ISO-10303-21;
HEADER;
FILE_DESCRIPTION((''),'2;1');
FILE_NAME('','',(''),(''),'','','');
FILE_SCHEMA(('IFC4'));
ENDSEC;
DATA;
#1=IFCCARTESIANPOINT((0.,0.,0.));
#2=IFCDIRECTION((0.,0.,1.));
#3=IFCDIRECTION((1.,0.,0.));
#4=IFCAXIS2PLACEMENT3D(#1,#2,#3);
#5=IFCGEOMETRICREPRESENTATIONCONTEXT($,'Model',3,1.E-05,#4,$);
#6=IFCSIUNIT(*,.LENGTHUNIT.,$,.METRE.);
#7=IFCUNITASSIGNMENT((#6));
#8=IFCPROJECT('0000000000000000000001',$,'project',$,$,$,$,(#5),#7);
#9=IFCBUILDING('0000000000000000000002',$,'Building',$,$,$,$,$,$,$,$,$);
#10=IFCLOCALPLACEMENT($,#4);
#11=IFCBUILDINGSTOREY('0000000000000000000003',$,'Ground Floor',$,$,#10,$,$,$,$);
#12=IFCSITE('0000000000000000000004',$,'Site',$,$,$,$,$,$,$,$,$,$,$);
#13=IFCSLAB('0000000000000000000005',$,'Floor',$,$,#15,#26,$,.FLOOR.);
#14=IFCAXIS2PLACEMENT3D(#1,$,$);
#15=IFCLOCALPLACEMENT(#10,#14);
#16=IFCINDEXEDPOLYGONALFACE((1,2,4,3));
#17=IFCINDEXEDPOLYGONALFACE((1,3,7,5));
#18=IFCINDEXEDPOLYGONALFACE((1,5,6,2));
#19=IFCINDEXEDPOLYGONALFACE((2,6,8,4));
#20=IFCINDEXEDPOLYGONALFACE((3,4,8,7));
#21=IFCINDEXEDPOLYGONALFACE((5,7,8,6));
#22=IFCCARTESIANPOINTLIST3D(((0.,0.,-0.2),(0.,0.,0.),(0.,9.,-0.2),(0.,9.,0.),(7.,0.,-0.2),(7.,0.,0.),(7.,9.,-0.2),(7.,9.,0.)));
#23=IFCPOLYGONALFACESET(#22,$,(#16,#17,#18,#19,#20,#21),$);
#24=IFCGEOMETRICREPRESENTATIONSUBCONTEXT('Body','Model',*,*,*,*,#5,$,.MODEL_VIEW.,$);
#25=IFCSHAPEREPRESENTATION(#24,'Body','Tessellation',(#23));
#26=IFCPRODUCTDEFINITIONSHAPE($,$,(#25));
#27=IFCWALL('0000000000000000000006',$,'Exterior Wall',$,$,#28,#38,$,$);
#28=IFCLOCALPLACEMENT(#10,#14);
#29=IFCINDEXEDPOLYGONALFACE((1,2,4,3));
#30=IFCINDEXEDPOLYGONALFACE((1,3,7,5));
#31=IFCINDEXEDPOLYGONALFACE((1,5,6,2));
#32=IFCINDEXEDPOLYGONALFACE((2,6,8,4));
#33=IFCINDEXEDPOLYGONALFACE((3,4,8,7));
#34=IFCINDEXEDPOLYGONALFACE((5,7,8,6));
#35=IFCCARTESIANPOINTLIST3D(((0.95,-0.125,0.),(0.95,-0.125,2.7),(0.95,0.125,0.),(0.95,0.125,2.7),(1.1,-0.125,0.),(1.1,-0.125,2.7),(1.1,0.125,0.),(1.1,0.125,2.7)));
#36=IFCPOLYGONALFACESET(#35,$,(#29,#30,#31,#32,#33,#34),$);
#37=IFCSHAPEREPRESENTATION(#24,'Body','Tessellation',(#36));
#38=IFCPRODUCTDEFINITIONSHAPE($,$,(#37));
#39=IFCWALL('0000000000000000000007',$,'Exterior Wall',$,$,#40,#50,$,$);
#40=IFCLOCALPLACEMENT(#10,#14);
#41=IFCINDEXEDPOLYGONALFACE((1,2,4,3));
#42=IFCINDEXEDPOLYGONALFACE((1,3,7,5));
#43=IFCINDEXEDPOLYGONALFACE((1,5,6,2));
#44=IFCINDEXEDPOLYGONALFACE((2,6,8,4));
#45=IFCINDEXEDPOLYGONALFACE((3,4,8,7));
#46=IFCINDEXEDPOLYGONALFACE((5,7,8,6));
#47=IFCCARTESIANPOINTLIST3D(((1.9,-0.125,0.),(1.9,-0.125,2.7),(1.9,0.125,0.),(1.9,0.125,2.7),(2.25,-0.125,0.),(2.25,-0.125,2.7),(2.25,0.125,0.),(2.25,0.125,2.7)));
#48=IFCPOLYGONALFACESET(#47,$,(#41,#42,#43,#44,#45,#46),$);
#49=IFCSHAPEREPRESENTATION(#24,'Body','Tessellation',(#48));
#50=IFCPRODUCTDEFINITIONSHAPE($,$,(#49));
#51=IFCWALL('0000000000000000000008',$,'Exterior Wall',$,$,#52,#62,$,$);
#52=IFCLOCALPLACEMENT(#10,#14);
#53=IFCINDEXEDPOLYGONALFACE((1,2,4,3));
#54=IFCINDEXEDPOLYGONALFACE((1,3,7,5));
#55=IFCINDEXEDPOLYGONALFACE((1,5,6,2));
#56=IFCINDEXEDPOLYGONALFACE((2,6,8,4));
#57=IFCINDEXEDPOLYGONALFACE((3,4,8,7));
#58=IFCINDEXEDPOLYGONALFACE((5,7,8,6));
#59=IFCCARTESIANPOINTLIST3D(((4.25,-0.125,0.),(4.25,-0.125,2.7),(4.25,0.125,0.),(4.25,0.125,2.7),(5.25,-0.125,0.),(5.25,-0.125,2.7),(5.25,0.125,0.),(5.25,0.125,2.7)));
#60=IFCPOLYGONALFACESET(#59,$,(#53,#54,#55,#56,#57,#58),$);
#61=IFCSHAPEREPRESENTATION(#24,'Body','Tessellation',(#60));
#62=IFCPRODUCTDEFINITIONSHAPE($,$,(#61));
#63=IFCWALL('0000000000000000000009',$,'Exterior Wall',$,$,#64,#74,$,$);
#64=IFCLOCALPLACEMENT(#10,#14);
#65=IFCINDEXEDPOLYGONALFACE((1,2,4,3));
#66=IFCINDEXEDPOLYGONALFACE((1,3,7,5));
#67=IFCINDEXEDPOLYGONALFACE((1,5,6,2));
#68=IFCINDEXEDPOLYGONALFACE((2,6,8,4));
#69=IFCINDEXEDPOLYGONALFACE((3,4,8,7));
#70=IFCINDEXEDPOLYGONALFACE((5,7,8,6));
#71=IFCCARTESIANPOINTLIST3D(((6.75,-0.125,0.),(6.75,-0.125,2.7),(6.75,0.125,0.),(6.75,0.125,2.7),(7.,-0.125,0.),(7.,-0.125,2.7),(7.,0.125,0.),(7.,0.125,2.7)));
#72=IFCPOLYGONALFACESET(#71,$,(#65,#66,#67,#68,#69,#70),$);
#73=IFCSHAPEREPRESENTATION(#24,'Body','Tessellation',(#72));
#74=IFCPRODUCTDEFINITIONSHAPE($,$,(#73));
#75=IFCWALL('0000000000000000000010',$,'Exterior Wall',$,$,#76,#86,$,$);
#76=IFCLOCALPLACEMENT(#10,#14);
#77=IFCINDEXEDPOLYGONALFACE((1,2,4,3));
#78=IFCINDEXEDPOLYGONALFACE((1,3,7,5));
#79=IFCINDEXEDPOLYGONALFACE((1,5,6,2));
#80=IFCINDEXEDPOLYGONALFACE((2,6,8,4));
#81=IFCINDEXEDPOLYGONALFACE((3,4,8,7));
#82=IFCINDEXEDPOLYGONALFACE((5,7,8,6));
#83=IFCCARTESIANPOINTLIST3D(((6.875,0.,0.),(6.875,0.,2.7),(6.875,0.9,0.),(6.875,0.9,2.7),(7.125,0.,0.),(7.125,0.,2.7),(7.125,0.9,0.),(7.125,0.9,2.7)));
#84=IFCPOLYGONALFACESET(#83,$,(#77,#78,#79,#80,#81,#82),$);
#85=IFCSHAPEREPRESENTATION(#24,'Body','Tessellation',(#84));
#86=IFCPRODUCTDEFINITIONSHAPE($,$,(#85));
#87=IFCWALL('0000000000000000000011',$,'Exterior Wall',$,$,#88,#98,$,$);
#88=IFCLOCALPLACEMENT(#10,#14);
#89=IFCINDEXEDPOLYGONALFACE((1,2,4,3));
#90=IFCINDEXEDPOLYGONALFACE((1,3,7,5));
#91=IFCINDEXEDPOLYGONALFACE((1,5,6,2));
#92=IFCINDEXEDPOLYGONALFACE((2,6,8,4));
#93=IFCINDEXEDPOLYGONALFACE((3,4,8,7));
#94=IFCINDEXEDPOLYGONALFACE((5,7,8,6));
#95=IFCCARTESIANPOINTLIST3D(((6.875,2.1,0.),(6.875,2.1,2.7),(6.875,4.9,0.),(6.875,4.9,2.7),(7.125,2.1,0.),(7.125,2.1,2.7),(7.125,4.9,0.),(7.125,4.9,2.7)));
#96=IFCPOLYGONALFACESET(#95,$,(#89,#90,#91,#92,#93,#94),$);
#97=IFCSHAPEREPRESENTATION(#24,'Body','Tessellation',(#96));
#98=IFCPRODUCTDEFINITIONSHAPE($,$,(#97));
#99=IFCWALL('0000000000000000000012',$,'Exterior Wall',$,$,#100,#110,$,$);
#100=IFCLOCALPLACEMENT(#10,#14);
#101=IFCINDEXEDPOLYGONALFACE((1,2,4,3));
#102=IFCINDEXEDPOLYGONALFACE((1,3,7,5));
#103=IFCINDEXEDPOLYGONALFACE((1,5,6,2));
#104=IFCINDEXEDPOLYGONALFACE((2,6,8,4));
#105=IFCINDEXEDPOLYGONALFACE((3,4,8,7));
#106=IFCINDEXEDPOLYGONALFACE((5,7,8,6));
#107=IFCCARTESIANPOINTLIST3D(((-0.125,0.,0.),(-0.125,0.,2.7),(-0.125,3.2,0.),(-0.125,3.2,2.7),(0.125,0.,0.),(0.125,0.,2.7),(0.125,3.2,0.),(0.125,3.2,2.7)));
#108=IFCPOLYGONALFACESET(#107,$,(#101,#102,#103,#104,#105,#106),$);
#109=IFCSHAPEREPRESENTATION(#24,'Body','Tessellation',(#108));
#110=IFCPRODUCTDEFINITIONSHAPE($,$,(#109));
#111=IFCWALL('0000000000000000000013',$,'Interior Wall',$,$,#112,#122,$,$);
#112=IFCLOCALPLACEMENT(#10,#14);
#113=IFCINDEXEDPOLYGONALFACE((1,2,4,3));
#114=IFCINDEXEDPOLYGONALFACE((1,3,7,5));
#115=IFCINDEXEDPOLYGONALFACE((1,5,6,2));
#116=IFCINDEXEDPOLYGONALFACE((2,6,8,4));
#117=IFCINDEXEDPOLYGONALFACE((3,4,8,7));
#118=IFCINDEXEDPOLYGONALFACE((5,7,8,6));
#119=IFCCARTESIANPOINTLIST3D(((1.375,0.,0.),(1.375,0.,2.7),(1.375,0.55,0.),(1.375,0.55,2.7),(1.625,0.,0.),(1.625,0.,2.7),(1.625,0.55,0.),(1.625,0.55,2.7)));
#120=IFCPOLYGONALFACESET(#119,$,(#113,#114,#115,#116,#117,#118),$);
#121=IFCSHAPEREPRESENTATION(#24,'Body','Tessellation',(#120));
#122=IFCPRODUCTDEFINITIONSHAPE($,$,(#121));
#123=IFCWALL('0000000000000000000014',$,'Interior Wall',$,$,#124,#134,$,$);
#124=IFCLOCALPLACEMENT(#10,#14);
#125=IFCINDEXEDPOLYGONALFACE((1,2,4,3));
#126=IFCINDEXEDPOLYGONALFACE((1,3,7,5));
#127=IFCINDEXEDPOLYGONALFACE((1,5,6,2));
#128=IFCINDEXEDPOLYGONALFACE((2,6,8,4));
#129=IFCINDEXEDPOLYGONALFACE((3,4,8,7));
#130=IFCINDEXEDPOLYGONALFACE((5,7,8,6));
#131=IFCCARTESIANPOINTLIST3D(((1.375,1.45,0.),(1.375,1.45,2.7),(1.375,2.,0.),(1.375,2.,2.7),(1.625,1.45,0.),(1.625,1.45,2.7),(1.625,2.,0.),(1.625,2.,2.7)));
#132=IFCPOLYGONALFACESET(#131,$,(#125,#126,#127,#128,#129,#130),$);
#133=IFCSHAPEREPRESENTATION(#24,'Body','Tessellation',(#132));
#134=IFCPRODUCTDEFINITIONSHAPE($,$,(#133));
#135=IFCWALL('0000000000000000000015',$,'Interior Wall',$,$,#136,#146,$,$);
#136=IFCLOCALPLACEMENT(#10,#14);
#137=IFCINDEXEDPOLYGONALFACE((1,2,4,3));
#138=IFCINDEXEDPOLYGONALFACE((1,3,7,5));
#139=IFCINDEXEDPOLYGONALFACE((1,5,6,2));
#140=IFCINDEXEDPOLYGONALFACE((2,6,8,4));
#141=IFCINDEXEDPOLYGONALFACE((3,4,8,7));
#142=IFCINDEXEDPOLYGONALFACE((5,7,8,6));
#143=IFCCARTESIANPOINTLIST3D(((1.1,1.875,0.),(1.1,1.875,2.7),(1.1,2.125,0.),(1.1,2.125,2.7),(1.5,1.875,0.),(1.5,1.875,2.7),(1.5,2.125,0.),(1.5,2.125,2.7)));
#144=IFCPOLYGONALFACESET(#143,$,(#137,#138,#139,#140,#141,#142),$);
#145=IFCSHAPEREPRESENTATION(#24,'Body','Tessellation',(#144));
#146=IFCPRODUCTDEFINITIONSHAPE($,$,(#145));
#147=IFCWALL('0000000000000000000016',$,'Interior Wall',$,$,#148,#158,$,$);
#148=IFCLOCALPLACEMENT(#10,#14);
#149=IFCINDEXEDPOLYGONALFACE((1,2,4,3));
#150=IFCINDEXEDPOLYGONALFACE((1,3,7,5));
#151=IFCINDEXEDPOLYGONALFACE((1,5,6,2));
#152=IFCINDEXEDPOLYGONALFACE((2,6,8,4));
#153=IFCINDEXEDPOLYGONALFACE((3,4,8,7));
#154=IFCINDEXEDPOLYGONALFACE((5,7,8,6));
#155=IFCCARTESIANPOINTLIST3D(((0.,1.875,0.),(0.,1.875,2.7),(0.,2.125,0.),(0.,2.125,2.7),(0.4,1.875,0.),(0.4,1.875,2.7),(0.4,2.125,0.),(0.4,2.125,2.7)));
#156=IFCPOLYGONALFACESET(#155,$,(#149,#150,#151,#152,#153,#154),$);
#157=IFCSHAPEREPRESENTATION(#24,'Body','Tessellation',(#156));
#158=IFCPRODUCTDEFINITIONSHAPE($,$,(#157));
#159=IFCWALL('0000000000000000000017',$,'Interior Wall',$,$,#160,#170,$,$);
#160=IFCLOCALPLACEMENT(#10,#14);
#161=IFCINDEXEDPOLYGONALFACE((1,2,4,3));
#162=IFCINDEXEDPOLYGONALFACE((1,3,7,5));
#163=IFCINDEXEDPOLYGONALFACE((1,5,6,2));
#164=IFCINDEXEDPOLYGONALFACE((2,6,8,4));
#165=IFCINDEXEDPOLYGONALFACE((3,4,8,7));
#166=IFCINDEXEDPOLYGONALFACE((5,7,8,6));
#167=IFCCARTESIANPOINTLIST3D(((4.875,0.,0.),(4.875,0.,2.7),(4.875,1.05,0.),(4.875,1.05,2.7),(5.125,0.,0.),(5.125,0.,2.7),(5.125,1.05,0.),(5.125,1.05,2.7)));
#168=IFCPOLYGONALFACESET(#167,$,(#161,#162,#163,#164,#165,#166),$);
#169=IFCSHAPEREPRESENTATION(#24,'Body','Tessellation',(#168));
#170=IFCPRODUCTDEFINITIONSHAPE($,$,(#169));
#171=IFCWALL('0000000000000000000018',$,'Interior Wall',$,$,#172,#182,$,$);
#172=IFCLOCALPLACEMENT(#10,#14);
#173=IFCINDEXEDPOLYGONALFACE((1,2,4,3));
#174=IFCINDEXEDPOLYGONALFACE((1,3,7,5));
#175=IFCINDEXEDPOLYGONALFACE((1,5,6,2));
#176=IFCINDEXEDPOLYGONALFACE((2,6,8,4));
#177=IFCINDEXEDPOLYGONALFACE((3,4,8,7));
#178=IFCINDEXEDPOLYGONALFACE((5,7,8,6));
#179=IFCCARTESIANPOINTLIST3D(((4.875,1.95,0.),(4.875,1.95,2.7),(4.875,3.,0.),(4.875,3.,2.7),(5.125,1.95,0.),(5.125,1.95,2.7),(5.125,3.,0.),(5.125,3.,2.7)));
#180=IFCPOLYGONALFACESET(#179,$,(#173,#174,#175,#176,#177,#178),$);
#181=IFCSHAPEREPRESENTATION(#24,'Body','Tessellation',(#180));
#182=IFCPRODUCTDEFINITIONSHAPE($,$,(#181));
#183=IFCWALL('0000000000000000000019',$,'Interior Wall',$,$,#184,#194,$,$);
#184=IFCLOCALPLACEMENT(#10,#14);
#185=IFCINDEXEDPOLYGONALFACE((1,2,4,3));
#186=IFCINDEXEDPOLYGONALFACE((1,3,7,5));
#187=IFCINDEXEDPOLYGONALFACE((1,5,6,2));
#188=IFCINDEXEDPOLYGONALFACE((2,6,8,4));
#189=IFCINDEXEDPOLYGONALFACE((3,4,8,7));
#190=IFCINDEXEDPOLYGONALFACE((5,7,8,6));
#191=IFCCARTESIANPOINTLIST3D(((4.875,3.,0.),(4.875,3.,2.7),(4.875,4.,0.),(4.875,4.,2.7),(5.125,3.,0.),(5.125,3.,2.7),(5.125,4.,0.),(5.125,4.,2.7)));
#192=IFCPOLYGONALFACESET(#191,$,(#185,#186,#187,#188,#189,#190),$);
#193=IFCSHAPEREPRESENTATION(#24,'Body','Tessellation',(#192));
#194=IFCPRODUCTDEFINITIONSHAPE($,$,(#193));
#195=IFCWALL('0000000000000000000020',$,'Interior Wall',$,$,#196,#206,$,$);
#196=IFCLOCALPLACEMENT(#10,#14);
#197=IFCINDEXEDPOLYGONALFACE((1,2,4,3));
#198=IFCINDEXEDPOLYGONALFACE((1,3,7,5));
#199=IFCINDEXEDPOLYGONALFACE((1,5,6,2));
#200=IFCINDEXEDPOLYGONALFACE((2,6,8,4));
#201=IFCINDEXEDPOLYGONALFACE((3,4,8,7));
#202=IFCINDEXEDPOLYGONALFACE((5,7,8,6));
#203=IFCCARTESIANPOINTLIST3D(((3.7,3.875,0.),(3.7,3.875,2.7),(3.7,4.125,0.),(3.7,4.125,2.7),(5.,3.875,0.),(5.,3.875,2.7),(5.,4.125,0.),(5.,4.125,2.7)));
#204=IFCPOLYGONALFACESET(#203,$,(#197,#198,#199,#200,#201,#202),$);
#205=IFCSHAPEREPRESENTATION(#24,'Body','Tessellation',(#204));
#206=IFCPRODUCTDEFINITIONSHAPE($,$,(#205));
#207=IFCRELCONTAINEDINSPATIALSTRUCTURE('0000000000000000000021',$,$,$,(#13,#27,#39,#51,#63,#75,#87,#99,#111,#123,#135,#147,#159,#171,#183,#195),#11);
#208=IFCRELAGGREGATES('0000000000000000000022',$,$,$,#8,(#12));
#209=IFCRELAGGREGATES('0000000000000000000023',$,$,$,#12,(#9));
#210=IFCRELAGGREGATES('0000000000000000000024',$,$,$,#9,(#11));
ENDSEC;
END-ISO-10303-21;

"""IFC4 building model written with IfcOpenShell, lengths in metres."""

from ifc_helpers import new_model, si_unit, frame, origin_with_axes, place, context, subcontext, project, spatial, indexed_curve, outline, extrude, element, save


model = new_model("IFC4")

# Units and contexts
model_context = context("Model", 3, precision=1e-05, world=origin_with_axes())
body_context = subcontext(model_context, "Body", "Model", "MODEL_VIEW")
ifc_project = project(units=[si_unit("LENGTHUNIT", "METRE")], contexts=[model_context])

# Site, building, storey
site = spatial("IfcSite", under=ifc_project, Name="Site")
building = spatial("IfcBuilding", under=site, Name="Building")
storey_placement = place(None, origin_with_axes())
storey = spatial("IfcBuildingStorey", under=building, at=storey_placement, Name="Ground Floor")

# Slab
slab_placement = place(storey_placement, frame((0.0, 0.0, -0.2), z_axis=(0.0, 0.0, 1.0), x_axis=(1.0, 0.0, 0.0)))
element("IfcSlab", 1, at=slab_placement, inside=storey, Name="Floor", PredefinedType="FLOOR", context=body_context, shape_type="SweptSolid", body=[
    extrude(outline(indexed_curve([(0.0, 0.0), (7.0, 0.0), (7.0, 9.0), (0.0, 9.0)])), None, (0.0, 0.0, 1.0), 0.2),
])

# Walls
wall_1_placement = place(storey_placement, frame((0.95, 0.0, 0.0), z_axis=(0.0, 0.0, 1.0), x_axis=(1.0, 0.0, 0.0)))
element("IfcWall", 2, at=wall_1_placement, inside=storey, Name="Exterior Wall", context=body_context, shape_type="SweptSolid", body=[
    extrude(outline(indexed_curve([(0.0, 0.0), (0.0, 0.25), (0.15, 0.25), (0.15, 0.0), (0.0, 0.0)], self_intersect=False)), frame((0.0, -0.125, 0.0), z_axis=(0.0, 0.0, 1.0), x_axis=(1.0, 0.0, 0.0)), (0.0, 0.0, 1.0), 2.7),
])
wall_2_placement = place(storey_placement, frame((1.9, 0.0, 0.0), z_axis=(0.0, 0.0, 1.0), x_axis=(1.0, 0.0, 0.0)))
element("IfcWall", 3, at=wall_2_placement, inside=storey, Name="Exterior Wall", context=body_context, shape_type="SweptSolid", body=[
    extrude(outline(indexed_curve([(0.0, 0.0), (0.0, 0.25), (0.35, 0.25), (0.35, 0.0), (0.0, 0.0)], self_intersect=False)), frame((0.0, -0.125, 0.0), z_axis=(0.0, 0.0, 1.0), x_axis=(1.0, 0.0, 0.0)), (0.0, 0.0, 1.0), 2.7),
])
wall_3_placement = place(storey_placement, frame((4.25, 0.0, 0.0), z_axis=(0.0, 0.0, 1.0), x_axis=(1.0, 0.0, 0.0)))
element("IfcWall", 4, at=wall_3_placement, inside=storey, Name="Exterior Wall", context=body_context, shape_type="SweptSolid", body=[
    extrude(outline(indexed_curve([(0.0, 0.0), (0.0, 0.25), (1.0, 0.25), (1.0, 0.0), (0.0, 0.0)], self_intersect=False)), frame((0.0, -0.125, 0.0), z_axis=(0.0, 0.0, 1.0), x_axis=(1.0, 0.0, 0.0)), (0.0, 0.0, 1.0), 2.7),
])
wall_4_placement = place(storey_placement, frame((6.75, 0.0, 0.0), z_axis=(0.0, 0.0, 1.0), x_axis=(1.0, 0.0, 0.0)))
element("IfcWall", 5, at=wall_4_placement, inside=storey, Name="Exterior Wall", context=body_context, shape_type="SweptSolid", body=[
    extrude(outline(indexed_curve([(0.0, 0.0), (0.0, 0.25), (0.25, 0.25), (0.25, 0.0), (0.0, 0.0)], self_intersect=False)), frame((0.0, -0.125, 0.0), z_axis=(0.0, 0.0, 1.0), x_axis=(1.0, 0.0, 0.0)), (0.0, 0.0, 1.0), 2.7),
])
wall_5_placement = place(storey_placement, frame((7.0, 0.0, 0.0), z_axis=(0.0, 0.0, 1.0), x_axis=(0.0, 1.0, 0.0)))
element("IfcWall", 6, at=wall_5_placement, inside=storey, Name="Exterior Wall", context=body_context, shape_type="SweptSolid", body=[
    extrude(outline(indexed_curve([(0.0, 0.0), (0.0, 0.25), (0.9, 0.25), (0.9, 0.0), (0.0, 0.0)], self_intersect=False)), frame((0.0, -0.125, 0.0), z_axis=(0.0, 0.0, 1.0), x_axis=(1.0, 0.0, 0.0)), (0.0, 0.0, 1.0), 2.7),
])
wall_6_placement = place(storey_placement, frame((7.0, 2.1, 0.0), z_axis=(0.0, 0.0, 1.0), x_axis=(0.0, 1.0, 0.0)))
element("IfcWall", 7, at=wall_6_placement, inside=storey, Name="Exterior Wall", context=body_context, shape_type="SweptSolid", body=[
    extrude(outline(indexed_curve([(0.0, 0.0), (0.0, 0.25), (2.8, 0.25), (2.8, 0.0), (0.0, 0.0)], self_intersect=False)), frame((0.0, -0.125, 0.0), z_axis=(0.0, 0.0, 1.0), x_axis=(1.0, 0.0, 0.0)), (0.0, 0.0, 1.0), 2.7),
])
wall_7_placement = place(storey_placement, frame((0.0, 3.2, 0.0), z_axis=(0.0, 0.0, 1.0), x_axis=(0.0, -1.0, 0.0)))
element("IfcWall", 8, at=wall_7_placement, inside=storey, Name="Exterior Wall", context=body_context, shape_type="SweptSolid", body=[
    extrude(outline(indexed_curve([(0.0, 0.0), (0.0, 0.25), (3.2, 0.25), (3.2, 0.0), (0.0, 0.0)], self_intersect=False)), frame((0.0, -0.125, 0.0), z_axis=(0.0, 0.0, 1.0), x_axis=(1.0, 0.0, 0.0)), (0.0, 0.0, 1.0), 2.7),
])
for number, where, z_axis, x_axis, name in (
    (9, (1.5, 0.0, 0.0), (0.0, 0.0, 1.0), (0.0, 1.0, 0.0), "Interior Wall"),
    (10, (1.5, 1.45, 0.0), (0.0, 0.0, 1.0), (0.0, 1.0, 0.0), "Interior Wall"),
):
    element("IfcWall", number, at=place(storey_placement, frame(where, z_axis=z_axis, x_axis=x_axis)), inside=storey, Name=name, context=body_context, shape_type="SweptSolid", body=[
        extrude(outline(indexed_curve([(0.0, 0.0), (0.0, 0.25), (0.55, 0.25), (0.55, 0.0), (0.0, 0.0)], self_intersect=False)), frame((0.0, -0.125, 0.0), z_axis=(0.0, 0.0, 1.0), x_axis=(1.0, 0.0, 0.0)), (0.0, 0.0, 1.0), 2.7),
    ])
for number, where, z_axis, x_axis, name in (
    (11, (1.5, 2.0, 0.0), (0.0, 0.0, 1.0), (-1.0, 0.0, 0.0), "Interior Wall"),
    (12, (0.4, 2.0, 0.0), (0.0, 0.0, 1.0), (-1.0, 0.0, 0.0), "Interior Wall"),
):
    element("IfcWall", number, at=place(storey_placement, frame(where, z_axis=z_axis, x_axis=x_axis)), inside=storey, Name=name, context=body_context, shape_type="SweptSolid", body=[
        extrude(outline(indexed_curve([(0.0, 0.0), (0.0, 0.25), (0.4, 0.25), (0.4, 0.0), (0.0, 0.0)], self_intersect=False)), frame((0.0, -0.125, 0.0), z_axis=(0.0, 0.0, 1.0), x_axis=(1.0, 0.0, 0.0)), (0.0, 0.0, 1.0), 2.7),
    ])
for number, where, z_axis, x_axis, name in (
    (13, (5.0, 0.0, 0.0), (0.0, 0.0, 1.0), (0.0, 1.0, 0.0), "Interior Wall"),
    (14, (5.0, 1.95, 0.0), (0.0, 0.0, 1.0), (0.0, 1.0, 0.0), "Interior Wall"),
):
    element("IfcWall", number, at=place(storey_placement, frame(where, z_axis=z_axis, x_axis=x_axis)), inside=storey, Name=name, context=body_context, shape_type="SweptSolid", body=[
        extrude(outline(indexed_curve([(0.0, 0.0), (0.0, 0.25), (1.05, 0.25), (1.05, 0.0), (0.0, 0.0)], self_intersect=False)), frame((0.0, -0.125, 0.0), z_axis=(0.0, 0.0, 1.0), x_axis=(1.0, 0.0, 0.0)), (0.0, 0.0, 1.0), 2.7),
    ])
wall_8_placement = place(storey_placement, frame((5.0, 3.0, 0.0), z_axis=(0.0, 0.0, 1.0), x_axis=(0.0, 1.0, 0.0)))
element("IfcWall", 15, at=wall_8_placement, inside=storey, Name="Interior Wall", context=body_context, shape_type="SweptSolid", body=[
    extrude(outline(indexed_curve([(0.0, 0.0), (0.0, 0.25), (1.0, 0.25), (1.0, 0.0), (0.0, 0.0)], self_intersect=False)), frame((0.0, -0.125, 0.0), z_axis=(0.0, 0.0, 1.0), x_axis=(1.0, 0.0, 0.0)), (0.0, 0.0, 1.0), 2.7),
])
for number, where, z_axis, x_axis, name in (
    (16, (5.0, 4.0, 0.0), (0.0, 0.0, 1.0), (-1.0, 0.0, 0.0), "Interior Wall"),
):
    element("IfcWall", number, at=place(storey_placement, frame(where, z_axis=z_axis, x_axis=x_axis)), inside=storey, Name=name, context=body_context, shape_type="SweptSolid", body=[
        extrude(outline(indexed_curve([(0.0, 0.0), (0.0, 0.25), (1.3, 0.25), (1.3, 0.0), (0.0, 0.0)], self_intersect=False)), frame((0.0, -0.125, 0.0), z_axis=(0.0, 0.0, 1.0), x_axis=(1.0, 0.0, 0.0)), (0.0, 0.0, 1.0), 2.7),
    ])

save(model, "model.ifc")
